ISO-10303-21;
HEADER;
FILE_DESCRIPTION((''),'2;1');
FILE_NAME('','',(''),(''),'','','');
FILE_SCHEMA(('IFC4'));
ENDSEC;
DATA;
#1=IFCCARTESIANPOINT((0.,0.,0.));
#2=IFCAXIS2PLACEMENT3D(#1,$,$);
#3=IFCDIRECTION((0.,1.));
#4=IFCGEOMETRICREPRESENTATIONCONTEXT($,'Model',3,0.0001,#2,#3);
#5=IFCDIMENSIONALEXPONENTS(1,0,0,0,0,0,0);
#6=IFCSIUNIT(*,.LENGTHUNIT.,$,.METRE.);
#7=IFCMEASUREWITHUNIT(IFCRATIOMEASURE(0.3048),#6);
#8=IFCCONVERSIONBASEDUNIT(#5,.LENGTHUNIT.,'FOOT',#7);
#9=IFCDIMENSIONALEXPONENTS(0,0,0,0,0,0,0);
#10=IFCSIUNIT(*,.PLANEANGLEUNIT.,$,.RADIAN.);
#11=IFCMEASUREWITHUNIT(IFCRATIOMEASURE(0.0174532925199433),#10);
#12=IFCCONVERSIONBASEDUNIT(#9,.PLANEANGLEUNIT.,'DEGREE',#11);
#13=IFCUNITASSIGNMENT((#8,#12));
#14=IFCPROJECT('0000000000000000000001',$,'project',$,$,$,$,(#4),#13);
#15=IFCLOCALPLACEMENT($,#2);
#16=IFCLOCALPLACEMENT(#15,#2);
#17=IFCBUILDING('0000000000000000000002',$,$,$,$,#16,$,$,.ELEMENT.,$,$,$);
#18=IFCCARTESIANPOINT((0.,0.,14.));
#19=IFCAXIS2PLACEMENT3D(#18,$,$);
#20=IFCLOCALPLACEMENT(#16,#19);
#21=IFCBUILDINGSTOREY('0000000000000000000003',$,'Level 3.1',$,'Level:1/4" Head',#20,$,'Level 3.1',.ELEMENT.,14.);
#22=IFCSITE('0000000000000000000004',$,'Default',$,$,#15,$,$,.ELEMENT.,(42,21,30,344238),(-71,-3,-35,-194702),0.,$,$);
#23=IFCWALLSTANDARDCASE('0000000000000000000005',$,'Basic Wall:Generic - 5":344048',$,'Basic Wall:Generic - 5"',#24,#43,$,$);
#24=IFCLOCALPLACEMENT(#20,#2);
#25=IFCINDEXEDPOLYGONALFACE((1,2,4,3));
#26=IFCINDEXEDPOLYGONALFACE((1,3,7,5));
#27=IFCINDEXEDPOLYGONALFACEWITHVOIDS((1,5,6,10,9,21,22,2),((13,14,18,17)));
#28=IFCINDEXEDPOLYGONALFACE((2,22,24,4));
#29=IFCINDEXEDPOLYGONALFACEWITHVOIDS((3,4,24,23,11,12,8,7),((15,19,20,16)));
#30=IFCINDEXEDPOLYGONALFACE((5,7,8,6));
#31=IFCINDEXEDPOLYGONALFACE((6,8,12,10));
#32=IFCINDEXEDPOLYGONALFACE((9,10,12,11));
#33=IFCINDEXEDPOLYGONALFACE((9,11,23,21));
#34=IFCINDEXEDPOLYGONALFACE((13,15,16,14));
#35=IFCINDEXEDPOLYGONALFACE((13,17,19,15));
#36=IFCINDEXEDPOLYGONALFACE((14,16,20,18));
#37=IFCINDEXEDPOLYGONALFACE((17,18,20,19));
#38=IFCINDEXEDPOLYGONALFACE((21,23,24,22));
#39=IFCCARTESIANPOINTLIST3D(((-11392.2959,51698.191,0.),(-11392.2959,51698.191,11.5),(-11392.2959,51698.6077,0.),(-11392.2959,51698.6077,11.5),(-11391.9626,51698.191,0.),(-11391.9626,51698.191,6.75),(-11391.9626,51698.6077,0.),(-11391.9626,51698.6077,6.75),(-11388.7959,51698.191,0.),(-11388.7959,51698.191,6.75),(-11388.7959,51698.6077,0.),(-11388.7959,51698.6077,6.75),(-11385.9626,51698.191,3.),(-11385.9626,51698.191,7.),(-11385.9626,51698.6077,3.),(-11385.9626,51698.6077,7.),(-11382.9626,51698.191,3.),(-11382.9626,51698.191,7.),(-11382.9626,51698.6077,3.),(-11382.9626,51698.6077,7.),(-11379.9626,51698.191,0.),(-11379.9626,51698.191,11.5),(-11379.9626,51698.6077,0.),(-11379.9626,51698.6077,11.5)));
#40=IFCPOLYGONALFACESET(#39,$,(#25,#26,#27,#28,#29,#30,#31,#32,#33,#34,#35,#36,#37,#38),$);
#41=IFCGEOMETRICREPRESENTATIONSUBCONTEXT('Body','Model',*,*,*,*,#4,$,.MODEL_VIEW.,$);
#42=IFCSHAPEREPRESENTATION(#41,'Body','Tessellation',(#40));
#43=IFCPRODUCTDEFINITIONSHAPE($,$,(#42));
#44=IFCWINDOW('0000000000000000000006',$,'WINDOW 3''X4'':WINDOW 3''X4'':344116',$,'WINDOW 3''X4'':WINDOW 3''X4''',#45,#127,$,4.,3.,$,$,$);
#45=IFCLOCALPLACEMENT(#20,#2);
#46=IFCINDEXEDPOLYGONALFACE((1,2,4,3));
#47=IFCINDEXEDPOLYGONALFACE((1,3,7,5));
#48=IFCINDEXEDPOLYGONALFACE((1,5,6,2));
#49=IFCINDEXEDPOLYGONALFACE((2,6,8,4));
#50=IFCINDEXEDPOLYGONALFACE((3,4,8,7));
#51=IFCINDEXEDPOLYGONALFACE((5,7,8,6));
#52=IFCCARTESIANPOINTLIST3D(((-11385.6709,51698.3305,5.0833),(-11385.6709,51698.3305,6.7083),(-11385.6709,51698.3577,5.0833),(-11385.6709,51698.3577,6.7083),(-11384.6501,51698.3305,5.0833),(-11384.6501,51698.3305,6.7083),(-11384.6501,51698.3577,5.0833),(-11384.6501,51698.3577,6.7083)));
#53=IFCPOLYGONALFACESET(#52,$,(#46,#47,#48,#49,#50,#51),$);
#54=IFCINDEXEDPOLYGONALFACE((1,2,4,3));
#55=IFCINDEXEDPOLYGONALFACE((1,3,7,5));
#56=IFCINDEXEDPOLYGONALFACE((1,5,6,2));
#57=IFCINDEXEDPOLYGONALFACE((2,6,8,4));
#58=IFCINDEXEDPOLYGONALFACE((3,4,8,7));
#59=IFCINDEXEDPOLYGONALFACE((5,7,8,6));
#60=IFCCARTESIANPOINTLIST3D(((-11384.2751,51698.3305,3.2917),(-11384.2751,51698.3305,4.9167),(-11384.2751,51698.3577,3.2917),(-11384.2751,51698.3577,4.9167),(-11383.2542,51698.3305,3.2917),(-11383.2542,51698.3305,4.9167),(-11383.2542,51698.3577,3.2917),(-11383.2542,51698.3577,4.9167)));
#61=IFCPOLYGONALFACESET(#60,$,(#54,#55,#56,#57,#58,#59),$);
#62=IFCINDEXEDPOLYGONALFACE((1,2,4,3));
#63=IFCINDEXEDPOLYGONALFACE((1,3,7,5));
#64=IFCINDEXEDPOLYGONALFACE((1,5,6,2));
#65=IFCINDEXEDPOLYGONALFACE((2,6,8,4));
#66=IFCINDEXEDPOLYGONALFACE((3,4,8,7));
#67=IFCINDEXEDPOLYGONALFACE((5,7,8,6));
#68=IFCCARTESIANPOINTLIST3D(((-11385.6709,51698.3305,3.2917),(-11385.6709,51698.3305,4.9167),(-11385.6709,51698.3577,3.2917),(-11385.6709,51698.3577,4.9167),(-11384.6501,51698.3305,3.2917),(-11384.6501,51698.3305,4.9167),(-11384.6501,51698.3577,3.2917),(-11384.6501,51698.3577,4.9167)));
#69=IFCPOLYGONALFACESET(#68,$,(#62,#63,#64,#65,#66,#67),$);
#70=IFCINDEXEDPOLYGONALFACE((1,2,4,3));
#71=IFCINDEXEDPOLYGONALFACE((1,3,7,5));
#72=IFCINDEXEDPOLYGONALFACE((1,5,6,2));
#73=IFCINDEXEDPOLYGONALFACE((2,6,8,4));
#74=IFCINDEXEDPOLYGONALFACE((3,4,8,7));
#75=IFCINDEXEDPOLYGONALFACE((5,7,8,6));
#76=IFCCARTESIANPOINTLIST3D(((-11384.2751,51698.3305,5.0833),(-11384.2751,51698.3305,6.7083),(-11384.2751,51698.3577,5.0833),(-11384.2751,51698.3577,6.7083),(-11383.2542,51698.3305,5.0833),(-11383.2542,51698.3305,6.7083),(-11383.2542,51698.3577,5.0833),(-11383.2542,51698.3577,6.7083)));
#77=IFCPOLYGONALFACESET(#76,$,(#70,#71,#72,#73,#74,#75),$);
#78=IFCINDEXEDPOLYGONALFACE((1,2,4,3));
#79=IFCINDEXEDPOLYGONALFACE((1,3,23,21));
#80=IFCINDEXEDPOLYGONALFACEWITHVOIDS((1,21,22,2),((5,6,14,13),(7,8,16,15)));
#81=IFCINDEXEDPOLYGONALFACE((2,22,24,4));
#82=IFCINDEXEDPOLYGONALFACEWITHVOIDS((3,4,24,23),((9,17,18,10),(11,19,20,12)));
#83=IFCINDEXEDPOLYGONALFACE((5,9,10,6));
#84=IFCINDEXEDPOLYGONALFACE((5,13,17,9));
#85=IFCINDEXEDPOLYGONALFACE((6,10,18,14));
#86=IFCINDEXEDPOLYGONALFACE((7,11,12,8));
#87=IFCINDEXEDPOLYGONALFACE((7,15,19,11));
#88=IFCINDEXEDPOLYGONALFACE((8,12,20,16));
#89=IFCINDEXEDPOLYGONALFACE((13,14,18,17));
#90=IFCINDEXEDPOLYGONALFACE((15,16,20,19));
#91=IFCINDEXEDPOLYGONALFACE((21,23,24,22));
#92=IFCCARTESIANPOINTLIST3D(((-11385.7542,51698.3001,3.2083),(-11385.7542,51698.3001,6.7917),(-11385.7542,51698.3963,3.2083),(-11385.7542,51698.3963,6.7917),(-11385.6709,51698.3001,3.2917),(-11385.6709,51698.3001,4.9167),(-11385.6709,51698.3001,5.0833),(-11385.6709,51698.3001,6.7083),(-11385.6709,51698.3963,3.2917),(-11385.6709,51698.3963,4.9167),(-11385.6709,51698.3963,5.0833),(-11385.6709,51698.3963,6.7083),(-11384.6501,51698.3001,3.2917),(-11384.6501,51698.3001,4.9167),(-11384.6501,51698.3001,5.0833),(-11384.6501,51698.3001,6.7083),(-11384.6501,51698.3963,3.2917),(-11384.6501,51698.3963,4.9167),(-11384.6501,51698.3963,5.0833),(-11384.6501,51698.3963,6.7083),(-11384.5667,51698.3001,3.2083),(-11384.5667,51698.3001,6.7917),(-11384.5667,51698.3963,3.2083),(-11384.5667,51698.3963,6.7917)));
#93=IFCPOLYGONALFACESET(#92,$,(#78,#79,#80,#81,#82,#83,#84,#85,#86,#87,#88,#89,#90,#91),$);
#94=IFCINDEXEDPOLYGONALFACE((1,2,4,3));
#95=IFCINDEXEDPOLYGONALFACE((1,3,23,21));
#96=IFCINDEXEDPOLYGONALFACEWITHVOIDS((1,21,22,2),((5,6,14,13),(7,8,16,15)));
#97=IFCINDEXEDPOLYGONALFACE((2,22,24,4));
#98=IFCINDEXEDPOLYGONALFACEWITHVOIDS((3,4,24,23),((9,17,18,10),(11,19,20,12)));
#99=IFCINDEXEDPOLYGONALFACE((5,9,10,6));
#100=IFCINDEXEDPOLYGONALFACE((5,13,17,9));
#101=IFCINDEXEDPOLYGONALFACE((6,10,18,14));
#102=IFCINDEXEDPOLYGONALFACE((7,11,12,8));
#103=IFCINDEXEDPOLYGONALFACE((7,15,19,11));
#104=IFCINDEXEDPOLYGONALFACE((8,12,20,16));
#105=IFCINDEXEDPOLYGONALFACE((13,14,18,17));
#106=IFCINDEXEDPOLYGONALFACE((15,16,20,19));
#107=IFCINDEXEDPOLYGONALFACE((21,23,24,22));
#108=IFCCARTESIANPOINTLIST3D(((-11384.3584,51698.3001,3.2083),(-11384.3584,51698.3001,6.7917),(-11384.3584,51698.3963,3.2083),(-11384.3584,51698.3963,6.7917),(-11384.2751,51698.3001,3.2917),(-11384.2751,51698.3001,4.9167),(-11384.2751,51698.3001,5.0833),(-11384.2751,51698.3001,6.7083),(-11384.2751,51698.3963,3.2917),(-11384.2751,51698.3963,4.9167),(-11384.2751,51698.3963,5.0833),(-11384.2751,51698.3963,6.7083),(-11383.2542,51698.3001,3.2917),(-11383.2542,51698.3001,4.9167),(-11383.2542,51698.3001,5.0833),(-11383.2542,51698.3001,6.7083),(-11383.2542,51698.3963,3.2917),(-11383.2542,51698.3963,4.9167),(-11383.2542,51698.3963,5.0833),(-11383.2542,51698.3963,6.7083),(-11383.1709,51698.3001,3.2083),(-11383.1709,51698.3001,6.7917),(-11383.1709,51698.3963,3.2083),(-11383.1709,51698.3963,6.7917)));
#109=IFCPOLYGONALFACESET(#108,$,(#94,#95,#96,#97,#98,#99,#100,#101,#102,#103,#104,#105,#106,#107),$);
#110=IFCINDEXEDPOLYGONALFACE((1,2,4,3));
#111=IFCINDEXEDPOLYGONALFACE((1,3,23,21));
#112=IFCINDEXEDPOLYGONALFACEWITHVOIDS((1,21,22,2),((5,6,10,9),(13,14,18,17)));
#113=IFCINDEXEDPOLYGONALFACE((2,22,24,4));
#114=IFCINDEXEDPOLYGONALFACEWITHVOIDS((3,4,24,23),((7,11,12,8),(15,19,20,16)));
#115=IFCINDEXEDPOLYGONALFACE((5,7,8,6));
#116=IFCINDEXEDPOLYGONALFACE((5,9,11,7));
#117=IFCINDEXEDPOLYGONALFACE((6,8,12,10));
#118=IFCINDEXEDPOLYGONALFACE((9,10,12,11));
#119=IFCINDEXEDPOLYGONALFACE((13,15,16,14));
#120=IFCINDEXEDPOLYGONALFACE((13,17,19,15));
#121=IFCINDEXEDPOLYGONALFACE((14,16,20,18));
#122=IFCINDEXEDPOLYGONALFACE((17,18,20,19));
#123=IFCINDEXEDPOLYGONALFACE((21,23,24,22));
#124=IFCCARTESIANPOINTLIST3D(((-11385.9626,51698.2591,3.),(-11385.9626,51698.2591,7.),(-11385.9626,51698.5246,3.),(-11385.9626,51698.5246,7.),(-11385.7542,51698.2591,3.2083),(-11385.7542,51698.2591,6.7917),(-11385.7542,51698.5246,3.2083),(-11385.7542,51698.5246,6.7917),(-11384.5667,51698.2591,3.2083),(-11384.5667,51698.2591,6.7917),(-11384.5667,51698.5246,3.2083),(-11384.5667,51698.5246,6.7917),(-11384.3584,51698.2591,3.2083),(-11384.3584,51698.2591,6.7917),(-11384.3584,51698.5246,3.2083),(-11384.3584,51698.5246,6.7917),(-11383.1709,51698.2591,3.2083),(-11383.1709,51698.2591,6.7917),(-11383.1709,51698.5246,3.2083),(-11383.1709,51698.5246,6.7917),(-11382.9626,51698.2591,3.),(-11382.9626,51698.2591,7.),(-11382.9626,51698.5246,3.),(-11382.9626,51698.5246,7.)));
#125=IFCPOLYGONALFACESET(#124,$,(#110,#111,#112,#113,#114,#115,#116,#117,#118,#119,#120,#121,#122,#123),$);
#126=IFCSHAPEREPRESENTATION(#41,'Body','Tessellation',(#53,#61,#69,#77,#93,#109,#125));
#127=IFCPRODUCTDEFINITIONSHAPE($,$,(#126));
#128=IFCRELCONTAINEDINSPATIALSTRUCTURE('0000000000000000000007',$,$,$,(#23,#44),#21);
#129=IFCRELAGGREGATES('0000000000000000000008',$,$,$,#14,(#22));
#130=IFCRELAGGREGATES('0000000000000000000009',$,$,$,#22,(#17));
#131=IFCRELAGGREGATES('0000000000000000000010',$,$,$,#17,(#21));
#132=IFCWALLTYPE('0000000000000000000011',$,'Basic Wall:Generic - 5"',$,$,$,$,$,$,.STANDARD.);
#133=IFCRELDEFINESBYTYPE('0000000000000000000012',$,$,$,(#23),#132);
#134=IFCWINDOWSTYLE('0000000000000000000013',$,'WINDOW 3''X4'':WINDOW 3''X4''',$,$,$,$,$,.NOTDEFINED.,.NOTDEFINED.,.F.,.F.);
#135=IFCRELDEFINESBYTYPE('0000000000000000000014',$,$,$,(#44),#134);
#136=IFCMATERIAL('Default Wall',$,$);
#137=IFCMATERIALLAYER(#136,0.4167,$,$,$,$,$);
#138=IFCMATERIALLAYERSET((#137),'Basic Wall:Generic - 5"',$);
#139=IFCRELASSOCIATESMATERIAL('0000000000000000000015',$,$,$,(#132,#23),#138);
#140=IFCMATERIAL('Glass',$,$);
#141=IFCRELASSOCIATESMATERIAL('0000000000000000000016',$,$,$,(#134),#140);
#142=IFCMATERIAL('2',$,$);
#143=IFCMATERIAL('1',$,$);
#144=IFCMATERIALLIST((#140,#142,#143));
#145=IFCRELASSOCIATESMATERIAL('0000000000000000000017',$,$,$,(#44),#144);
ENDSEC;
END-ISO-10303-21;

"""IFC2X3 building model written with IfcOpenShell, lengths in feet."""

from ifc_helpers import new_model, entity, si_unit, converted_unit, direction, frame, frame_2d, origin, origin_2d_with_axis, place, context, subcontext, project, spatial, polyline, rectangle, outline, extrude, source, transform, mapped, material, material_list, layer, layer_set, layer_usage, type_object, type_shapes, element, fill, save


model = new_model("IFC2X3")

# Units and contexts
model_context = context("Model", 3, precision=0.0001, world=origin(), true_north=direction((0.0, 1.0)))
body_context = subcontext(model_context, "Body", "Model", "MODEL_VIEW")
ifc_project = project(units=[converted_unit("LENGTHUNIT", "FOOT", entity("IfcRatioMeasure", 0.3048), si_unit("LENGTHUNIT", "METRE"), dimensions=[1, 0, 0, 0, 0, 0, 0]), converted_unit("PLANEANGLEUNIT", "DEGREE", entity("IfcRatioMeasure", 0.0174532925199433), si_unit("PLANEANGLEUNIT", "RADIAN"), dimensions=[0, 0, 0, 0, 0, 0, 0])], contexts=[model_context])

# Site, building, storey
site_placement = place(None, origin())
site = spatial("IfcSite", under=ifc_project, at=site_placement, Name="Default", CompositionType="ELEMENT", RefLatitude=(42, 21, 30, 344238), RefLongitude=(-71, -3, -35, -194702), RefElevation=0.0)
building_placement = place(site_placement, origin())
building = spatial("IfcBuilding", under=site, at=building_placement, CompositionType="ELEMENT")
storey_placement = place(building_placement, frame((0.0, 0.0, 14.0)))
storey = spatial("IfcBuildingStorey", under=building, at=storey_placement, Name="Level 3.1", ObjectType="Level:1/4\" Head", LongName="Level 3.1", CompositionType="ELEMENT", Elevation=14.0)

# Shared definitions
ifc_material_1 = material(Name="Default Wall")
ifc_material_2 = material(Name="Glass")
ifc_material_3 = material(Name="2")
ifc_material_4 = material(Name="1")
ifc_layer_1 = layer(ifc_material_1, 0.4167)
ifc_layer_set_1 = layer_set([ifc_layer_1], Name="Basic Wall:Generic - 5\"")
wall_type_1 = type_object("IfcWallType", Name="Basic Wall:Generic - 5\"", PredefinedType="STANDARD", material=ifc_layer_set_1)

# Wall, openings, window
window_style_1 = type_object("IfcWindowStyle", Name="WINDOW 3'X4':WINDOW 3'X4'", ConstructionType="NOTDEFINED", OperationType="NOTDEFINED", ParameterTakesPrecedence=False, Sizeable=False, material=ifc_material_2)
shared_shape_1 = source(origin(), body_context, "Body", "SweptSolid", [
    extrude(rectangle(XDim=0.0272, YDim=1.0208, at=origin_2d_with_axis()), frame((2.1979, 0.2636, 2.0833), z_axis=(0.0, 0.0, 1.0), x_axis=(0.0, 1.0, 0.0)), (0.0, 0.0, 1.0), 1.625),
    extrude(rectangle(XDim=0.0272, YDim=1.0208, at=origin_2d_with_axis()), frame((0.8021, 0.2636, 0.2917), z_axis=(0.0, 0.0, 1.0), x_axis=(0.0, 1.0, 0.0)), (0.0, 0.0, 1.0), 1.625),
    extrude(rectangle(XDim=0.0272, YDim=1.0208, at=origin_2d_with_axis()), frame((2.1979, 0.2636, 0.2917), z_axis=(0.0, 0.0, 1.0), x_axis=(0.0, 1.0, 0.0)), (0.0, 0.0, 1.0), 1.625),
    extrude(rectangle(XDim=0.0272, YDim=1.0208, at=origin_2d_with_axis()), frame((0.8021, 0.2636, 2.0833), z_axis=(0.0, 0.0, 1.0), x_axis=(0.0, 1.0, 0.0)), (0.0, 0.0, 1.0), 1.625),
    extrude(outline(polyline([(-0.5938, -1.7917), (0.5938, -1.7917), (0.5938, 1.7917), (-0.5938, 1.7917), (-0.5938, -1.7917)]), holes=[polyline([(-0.5104, -0.0833), (0.5104, -0.0833), (0.5104, -1.7083), (-0.5104, -1.7083), (-0.5104, -0.0833)]), polyline([(-0.5104, 1.7083), (0.5104, 1.7083), (0.5104, 0.0833), (-0.5104, 0.0833), (-0.5104, 1.7083)])]), frame((2.1979, 0.2114, 2.0), z_axis=(0.0, 1.0, 0.0), x_axis=(-1.0, 0.0, 0.0)), (0.0, 0.0, 1.0), 0.0962),
    extrude(outline(polyline([(-1.7917, -0.5937), (1.7917, -0.5937), (1.7917, 0.5937), (-1.7917, 0.5937), (-1.7917, -0.5937)]), holes=[polyline([(0.0833, -0.5104), (0.0833, 0.5104), (1.7083, 0.5104), (1.7083, -0.5104), (0.0833, -0.5104)]), polyline([(-1.7083, -0.5104), (-1.7083, 0.5104), (-0.0833, 0.5104), (-0.0833, -0.5104), (-1.7083, -0.5104)])]), frame((0.8021, 0.2114, 2.0), z_axis=(0.0, 1.0, 0.0), x_axis=(0.0, 0.0, -1.0)), (0.0, 0.0, 1.0), 0.0962),
    extrude(outline(polyline([(-1.5, -2.0), (1.5, -2.0), (1.5, 2.0), (-1.5, 2.0), (-1.5, -2.0)]), holes=[polyline([(-0.1042, 1.7917), (-0.1042, -1.7917), (-1.2917, -1.7917), (-1.2917, 1.7917), (-0.1042, 1.7917)]), polyline([(0.1042, -1.7917), (0.1042, 1.7917), (1.2917, 1.7917), (1.2917, -1.7917), (0.1042, -1.7917)])]), frame((1.5, 0.0831, 2.0), z_axis=(0.0, 1.0, 0.0), x_axis=(1.0, 0.0, 0.0)), (0.0, 0.0, 1.0), 0.2655),
])
type_shapes(window_style_1, [shared_shape_1])
ifc_layer_usage_1 = layer_usage(ifc_layer_set_1, "AXIS2", "NEGATIVE", 0.2083)
wall_1_placement = place(storey_placement, frame((-11379.9626, 51698.3993, 0.0), z_axis=(0.0, 0.0, 1.0), x_axis=(-1.0, 0.0, 0.0)))
wall_1 = element("IfcWallStandardCase", 1, at=wall_1_placement, inside=storey, type_object=wall_type_1, material=ifc_layer_usage_1, Name="Basic Wall:Generic - 5\":344048", ObjectType="Basic Wall:Generic - 5\"", context=body_context, shape_type="SweptSolid", body=[
    extrude(rectangle(XDim=12.3333, YDim=0.4167, at=frame_2d((6.1667, 0.0), x_axis=(-1.0, 0.0))), origin(), (0.0, 0.0, 1.0), 11.5),
])
opening_1_placement = place(wall_1_placement, frame((12.0, 0.2083, 0.0)))
element("IfcOpeningElement", 2, at=opening_1_placement, cuts=wall_1, ObjectType="Opening", context=body_context, shape_type="SweptSolid", body=[
    extrude(rectangle(XDim=6.75, YDim=3.1667, at=frame_2d((3.375, 1.5833), x_axis=(1.0, 0.0))), frame((0.0, 0.0, 0.0), z_axis=(0.0, -1.0, 0.0), x_axis=(0.0, 0.0, 1.0)), (0.0, 0.0, 1.0), 0.4167),
])
opening_2_placement = place(wall_1_placement, frame((3.0, -0.2083, 3.0)))
opening_2 = element("IfcOpeningElement", 3, at=opening_2_placement, cuts=wall_1, ObjectType="Opening", context=body_context, shape_type="SweptSolid", body=[
    extrude(rectangle(XDim=4.0, YDim=3.0, at=frame_2d((2.0, 1.5), x_axis=(-1.0, 0.0))), frame((0.0, 0.0, 0.0), z_axis=(0.0, 1.0, 0.0), x_axis=(0.0, 0.0, 1.0)), (0.0, 0.0, 1.0), 0.4167),
])
ifc_material_list_1 = material_list([ifc_material_2, ifc_material_3, ifc_material_4])
window_1_placement = place(opening_2_placement, origin())
window_1 = element("IfcWindow", 4, at=window_1_placement, inside=storey, type_object=window_style_1, material=ifc_material_list_1, Name="WINDOW 3'X4':WINDOW 3'X4':344116", ObjectType="WINDOW 3'X4':WINDOW 3'X4'", OverallHeight=4.0, OverallWidth=3.0, context=body_context, shape_type="MappedRepresentation", body=[
    mapped(shared_shape_1, transform((0.0, 0.0, 0.0), scale=1.0)),
])
fill(opening_2, window_1)

save(model, "model.ifc")
